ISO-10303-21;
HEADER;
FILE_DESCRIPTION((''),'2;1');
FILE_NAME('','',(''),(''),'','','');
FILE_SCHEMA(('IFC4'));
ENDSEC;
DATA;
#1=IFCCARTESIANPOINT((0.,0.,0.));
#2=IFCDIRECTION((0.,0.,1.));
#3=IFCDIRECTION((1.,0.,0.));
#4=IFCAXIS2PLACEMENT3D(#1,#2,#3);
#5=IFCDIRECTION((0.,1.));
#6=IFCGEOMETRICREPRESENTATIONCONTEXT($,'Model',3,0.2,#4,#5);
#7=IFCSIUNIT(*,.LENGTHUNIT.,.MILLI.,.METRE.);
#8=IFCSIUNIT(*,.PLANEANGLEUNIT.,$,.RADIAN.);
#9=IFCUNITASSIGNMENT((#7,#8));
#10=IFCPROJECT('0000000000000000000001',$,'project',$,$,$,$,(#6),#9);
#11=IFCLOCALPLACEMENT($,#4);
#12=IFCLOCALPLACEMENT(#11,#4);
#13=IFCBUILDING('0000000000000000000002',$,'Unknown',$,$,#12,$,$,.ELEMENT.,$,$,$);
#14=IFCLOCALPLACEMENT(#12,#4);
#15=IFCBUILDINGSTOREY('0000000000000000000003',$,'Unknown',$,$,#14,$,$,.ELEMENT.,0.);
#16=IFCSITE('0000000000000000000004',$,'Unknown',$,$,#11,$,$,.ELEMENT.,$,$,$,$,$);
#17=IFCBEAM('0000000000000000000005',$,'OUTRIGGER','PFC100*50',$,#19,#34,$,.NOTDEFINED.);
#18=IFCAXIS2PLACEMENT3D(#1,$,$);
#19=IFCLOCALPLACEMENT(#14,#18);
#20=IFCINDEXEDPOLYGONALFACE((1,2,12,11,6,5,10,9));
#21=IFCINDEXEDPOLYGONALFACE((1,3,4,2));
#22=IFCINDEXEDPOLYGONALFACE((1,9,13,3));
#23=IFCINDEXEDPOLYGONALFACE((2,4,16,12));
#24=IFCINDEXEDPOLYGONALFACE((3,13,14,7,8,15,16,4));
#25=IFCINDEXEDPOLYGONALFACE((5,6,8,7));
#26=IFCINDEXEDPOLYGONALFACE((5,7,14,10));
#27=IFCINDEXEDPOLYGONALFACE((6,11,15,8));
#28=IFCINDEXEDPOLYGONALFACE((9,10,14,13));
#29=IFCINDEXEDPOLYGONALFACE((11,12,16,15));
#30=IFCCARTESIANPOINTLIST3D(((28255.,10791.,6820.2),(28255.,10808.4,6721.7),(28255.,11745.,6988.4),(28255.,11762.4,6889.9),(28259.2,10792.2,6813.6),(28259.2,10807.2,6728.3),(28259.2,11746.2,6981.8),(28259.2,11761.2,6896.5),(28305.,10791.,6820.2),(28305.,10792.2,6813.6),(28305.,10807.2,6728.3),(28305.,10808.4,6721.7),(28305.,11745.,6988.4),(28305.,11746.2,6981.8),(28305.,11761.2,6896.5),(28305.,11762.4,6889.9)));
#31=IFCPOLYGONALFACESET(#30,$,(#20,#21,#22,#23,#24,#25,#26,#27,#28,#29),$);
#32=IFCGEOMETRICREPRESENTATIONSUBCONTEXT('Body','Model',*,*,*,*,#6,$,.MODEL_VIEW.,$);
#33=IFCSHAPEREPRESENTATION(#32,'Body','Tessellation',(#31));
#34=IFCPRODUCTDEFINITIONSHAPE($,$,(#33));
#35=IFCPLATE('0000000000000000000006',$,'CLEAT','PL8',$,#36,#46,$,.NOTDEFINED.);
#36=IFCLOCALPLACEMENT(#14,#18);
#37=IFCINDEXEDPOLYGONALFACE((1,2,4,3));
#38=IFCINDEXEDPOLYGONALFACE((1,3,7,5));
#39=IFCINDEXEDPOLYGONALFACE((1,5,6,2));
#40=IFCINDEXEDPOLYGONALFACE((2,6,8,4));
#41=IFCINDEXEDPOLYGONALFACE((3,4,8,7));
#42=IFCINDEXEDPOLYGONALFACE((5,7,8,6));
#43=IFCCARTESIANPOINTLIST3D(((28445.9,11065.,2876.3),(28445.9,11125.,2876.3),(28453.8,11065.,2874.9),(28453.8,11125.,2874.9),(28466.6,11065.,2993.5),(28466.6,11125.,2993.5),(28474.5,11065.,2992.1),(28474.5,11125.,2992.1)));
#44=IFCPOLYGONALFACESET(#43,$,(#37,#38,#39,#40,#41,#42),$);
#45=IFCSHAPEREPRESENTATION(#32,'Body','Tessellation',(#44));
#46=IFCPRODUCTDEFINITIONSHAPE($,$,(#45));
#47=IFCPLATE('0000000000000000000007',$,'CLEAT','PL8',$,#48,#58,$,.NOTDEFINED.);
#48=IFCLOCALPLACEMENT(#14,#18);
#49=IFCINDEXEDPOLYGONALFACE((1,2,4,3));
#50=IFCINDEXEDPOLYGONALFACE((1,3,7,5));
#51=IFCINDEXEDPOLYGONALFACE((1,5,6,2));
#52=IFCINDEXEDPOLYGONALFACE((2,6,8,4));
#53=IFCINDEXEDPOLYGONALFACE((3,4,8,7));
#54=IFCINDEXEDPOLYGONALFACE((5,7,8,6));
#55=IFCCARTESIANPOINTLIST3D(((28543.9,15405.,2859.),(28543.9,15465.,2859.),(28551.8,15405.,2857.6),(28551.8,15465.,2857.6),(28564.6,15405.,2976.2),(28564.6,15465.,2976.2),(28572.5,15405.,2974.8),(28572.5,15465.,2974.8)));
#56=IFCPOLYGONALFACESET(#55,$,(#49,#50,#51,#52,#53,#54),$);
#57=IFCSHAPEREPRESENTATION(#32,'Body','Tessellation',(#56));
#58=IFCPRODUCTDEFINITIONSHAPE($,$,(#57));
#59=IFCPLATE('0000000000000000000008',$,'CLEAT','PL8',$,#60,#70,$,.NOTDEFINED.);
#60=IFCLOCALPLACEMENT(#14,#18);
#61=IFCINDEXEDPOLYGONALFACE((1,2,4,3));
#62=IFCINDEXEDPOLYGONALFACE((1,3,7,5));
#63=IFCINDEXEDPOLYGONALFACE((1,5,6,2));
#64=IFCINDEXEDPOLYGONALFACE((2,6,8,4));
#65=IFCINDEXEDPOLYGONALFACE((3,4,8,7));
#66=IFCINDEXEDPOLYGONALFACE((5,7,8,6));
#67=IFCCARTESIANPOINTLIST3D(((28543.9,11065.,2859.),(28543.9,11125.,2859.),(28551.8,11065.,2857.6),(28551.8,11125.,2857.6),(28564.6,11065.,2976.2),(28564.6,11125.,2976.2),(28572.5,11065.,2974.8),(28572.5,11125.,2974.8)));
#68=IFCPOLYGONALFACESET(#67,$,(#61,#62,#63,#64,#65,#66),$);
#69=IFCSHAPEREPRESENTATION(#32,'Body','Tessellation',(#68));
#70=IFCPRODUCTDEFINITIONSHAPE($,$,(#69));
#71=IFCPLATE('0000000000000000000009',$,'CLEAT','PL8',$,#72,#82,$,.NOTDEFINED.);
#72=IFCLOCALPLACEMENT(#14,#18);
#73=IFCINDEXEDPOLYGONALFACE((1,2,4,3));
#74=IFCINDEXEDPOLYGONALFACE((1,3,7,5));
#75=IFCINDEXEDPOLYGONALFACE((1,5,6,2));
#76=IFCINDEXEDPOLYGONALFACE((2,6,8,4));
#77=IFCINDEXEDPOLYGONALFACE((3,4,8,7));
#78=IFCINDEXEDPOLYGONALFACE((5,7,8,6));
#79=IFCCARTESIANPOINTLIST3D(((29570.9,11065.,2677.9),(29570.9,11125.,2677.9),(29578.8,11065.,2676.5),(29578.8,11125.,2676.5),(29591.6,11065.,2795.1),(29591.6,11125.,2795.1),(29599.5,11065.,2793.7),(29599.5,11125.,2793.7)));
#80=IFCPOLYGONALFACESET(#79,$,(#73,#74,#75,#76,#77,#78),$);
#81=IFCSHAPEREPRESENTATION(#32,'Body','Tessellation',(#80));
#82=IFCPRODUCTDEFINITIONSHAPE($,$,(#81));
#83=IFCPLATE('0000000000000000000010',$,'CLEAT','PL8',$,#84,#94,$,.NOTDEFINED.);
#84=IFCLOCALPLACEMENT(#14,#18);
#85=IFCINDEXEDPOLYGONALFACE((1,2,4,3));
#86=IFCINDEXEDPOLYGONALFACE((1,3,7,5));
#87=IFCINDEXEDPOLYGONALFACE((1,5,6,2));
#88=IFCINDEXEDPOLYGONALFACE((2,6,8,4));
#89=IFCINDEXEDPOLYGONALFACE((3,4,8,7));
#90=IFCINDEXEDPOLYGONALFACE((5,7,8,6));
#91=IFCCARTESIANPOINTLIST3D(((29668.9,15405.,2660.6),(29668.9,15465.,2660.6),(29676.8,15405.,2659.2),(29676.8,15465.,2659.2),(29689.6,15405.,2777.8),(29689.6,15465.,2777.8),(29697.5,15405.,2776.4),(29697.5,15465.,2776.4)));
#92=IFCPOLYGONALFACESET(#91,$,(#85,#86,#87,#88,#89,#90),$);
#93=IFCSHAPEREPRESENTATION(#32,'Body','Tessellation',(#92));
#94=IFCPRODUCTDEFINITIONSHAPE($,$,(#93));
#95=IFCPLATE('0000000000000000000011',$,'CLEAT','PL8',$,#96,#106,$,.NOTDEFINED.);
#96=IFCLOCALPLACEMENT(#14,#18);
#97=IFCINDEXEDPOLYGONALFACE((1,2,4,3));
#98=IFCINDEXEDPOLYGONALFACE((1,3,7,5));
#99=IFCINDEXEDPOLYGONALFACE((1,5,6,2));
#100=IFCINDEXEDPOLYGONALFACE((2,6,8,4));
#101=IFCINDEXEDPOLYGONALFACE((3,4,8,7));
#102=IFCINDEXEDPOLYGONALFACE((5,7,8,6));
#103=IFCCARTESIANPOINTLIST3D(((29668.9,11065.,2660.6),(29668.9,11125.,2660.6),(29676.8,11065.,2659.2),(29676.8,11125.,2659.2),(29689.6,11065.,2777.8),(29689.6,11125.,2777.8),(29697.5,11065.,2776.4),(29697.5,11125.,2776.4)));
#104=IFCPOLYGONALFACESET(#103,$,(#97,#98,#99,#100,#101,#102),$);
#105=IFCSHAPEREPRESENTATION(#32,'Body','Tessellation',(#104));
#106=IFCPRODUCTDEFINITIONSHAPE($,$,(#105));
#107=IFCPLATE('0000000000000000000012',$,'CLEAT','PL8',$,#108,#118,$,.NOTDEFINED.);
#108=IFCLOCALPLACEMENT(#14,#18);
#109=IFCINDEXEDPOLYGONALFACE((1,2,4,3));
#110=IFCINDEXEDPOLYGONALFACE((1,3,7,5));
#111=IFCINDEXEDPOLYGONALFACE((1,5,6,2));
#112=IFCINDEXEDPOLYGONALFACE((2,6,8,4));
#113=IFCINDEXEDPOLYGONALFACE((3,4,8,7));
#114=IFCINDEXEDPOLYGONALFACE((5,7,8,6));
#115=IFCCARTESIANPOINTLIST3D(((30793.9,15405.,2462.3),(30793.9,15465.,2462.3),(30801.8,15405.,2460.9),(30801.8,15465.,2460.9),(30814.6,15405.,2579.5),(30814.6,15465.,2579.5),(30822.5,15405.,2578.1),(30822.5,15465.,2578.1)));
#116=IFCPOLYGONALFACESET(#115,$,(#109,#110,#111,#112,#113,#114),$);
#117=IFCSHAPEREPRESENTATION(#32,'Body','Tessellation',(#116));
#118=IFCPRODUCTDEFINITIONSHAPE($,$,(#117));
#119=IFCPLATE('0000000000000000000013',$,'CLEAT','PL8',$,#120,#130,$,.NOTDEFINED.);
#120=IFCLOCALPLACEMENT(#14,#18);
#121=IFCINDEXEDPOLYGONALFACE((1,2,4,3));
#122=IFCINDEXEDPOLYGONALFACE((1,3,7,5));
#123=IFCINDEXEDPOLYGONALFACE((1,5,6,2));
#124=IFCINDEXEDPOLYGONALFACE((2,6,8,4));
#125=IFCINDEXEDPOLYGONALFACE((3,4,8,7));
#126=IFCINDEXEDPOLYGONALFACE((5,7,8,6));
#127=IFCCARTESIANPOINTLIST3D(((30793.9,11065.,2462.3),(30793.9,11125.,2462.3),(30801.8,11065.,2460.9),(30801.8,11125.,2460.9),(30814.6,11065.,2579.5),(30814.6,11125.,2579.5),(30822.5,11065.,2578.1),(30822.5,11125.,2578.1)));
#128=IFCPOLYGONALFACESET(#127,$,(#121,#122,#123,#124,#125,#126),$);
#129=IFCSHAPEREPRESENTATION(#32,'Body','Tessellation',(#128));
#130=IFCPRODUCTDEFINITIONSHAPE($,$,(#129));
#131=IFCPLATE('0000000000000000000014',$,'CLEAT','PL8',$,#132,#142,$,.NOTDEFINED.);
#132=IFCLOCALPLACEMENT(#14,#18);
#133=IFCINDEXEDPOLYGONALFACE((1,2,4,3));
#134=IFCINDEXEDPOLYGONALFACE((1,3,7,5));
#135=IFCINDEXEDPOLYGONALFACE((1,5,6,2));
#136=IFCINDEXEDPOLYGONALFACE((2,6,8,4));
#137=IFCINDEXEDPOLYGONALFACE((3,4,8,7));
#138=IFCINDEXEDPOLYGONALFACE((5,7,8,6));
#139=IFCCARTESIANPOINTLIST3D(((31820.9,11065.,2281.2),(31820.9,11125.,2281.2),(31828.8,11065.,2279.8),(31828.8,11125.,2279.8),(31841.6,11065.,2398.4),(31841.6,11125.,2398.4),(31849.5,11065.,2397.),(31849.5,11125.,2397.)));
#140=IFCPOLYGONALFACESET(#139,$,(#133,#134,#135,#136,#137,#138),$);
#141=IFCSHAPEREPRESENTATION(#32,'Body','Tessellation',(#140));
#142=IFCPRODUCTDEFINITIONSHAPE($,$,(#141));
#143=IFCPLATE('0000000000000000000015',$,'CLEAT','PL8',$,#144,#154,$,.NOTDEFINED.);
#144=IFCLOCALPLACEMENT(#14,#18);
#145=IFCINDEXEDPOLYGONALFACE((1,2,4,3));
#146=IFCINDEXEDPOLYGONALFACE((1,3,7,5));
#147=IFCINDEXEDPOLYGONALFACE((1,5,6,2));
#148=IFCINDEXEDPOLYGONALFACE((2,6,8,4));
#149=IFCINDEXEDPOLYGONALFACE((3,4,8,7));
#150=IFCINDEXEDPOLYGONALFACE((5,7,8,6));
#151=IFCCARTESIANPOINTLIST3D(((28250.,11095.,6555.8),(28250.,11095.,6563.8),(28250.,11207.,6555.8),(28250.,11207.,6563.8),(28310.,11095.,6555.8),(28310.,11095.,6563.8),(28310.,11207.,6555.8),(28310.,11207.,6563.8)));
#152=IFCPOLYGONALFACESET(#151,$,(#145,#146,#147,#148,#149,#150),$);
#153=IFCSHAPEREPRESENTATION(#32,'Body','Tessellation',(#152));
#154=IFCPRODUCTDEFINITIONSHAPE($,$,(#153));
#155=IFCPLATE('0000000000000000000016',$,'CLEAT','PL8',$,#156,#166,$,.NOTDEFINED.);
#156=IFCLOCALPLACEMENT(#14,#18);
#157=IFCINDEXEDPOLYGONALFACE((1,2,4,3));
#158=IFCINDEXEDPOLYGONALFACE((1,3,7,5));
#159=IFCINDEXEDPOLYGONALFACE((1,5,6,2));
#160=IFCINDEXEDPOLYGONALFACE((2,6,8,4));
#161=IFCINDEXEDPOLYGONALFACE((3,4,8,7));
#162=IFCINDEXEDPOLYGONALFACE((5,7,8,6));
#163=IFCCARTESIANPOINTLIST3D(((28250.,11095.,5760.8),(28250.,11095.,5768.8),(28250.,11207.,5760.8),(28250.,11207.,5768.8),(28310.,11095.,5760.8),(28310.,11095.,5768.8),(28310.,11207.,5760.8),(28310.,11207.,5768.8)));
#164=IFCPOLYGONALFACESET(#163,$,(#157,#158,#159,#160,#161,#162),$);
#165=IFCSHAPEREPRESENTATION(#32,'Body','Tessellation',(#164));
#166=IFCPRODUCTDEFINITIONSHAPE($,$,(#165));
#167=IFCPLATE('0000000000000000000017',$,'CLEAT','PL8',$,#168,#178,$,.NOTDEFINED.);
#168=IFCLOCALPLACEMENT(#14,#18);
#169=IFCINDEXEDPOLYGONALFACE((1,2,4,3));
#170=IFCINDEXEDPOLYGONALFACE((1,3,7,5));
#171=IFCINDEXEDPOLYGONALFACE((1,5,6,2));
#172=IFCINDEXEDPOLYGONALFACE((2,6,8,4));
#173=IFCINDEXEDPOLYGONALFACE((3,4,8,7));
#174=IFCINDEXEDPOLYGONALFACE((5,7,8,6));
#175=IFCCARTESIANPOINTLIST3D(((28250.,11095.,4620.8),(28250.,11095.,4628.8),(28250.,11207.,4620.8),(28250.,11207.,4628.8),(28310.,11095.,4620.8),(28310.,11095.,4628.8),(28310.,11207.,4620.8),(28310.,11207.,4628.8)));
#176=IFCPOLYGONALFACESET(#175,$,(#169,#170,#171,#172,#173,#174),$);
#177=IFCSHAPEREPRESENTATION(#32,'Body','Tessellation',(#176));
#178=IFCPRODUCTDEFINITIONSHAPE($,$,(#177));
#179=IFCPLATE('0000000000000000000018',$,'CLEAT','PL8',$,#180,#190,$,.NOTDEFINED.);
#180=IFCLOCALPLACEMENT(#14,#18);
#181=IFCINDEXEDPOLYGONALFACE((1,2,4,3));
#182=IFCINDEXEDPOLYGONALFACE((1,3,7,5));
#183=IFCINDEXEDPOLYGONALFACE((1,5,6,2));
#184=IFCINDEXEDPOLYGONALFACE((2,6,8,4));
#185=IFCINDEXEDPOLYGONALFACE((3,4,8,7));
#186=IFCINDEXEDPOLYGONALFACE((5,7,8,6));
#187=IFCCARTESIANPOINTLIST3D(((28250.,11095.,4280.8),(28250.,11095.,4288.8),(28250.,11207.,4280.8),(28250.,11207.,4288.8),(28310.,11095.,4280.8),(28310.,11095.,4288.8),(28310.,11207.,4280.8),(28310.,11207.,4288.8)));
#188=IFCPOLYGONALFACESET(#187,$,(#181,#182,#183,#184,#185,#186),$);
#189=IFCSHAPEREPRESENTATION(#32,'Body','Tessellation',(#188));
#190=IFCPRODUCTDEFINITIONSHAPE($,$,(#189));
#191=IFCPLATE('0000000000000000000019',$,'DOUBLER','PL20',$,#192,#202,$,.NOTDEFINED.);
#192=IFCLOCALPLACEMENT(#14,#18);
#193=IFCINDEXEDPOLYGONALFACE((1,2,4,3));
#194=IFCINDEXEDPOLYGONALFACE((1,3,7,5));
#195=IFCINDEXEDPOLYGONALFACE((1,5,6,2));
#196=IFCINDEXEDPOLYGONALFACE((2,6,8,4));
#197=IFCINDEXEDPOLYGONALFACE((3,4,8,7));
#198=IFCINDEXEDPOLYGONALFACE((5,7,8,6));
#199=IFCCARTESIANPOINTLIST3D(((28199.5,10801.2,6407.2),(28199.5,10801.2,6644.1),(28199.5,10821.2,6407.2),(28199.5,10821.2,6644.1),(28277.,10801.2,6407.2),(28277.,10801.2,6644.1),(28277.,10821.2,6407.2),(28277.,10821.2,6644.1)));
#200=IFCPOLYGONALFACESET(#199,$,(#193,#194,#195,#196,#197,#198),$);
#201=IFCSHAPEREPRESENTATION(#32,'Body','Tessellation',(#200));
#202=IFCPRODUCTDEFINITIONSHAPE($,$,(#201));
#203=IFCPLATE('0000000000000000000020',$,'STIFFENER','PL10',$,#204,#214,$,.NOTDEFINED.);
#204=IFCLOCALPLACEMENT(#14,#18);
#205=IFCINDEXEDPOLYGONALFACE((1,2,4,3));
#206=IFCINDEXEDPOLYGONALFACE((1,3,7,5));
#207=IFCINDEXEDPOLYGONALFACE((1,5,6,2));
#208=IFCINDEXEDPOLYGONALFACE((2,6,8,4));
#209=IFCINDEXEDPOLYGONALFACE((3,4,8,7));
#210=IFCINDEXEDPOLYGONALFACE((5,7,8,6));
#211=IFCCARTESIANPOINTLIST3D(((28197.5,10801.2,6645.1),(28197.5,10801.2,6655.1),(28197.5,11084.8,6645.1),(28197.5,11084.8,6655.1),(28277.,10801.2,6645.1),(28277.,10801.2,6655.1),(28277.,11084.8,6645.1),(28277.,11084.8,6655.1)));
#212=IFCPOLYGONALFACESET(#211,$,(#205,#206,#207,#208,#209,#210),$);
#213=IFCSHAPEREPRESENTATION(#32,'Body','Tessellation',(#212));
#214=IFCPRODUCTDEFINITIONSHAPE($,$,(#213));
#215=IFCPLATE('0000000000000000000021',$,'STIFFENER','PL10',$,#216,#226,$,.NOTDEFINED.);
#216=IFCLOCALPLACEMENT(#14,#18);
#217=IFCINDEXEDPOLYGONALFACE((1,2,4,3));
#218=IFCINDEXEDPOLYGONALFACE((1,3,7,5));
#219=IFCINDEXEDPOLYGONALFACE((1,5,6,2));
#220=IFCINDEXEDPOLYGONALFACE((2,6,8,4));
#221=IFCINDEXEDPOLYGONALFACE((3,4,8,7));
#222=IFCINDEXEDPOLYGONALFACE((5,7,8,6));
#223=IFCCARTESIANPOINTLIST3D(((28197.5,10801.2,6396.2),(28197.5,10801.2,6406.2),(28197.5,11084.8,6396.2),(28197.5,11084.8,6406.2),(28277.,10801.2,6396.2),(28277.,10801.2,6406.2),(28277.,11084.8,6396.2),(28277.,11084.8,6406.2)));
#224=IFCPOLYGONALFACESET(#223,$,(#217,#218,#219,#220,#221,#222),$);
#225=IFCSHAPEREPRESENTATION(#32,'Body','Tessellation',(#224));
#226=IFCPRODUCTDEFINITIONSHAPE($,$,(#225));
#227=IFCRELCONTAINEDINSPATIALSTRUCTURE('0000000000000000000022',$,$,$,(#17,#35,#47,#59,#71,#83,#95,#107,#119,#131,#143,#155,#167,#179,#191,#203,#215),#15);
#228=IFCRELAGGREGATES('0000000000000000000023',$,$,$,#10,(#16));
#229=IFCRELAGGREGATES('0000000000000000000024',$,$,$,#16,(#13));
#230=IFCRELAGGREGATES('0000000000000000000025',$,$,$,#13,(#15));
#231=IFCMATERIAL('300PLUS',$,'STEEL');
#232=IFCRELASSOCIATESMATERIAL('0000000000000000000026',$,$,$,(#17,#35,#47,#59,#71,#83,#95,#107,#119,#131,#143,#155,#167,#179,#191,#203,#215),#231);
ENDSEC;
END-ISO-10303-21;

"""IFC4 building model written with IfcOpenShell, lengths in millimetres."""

from ifc_helpers import new_model, si_unit, direction, frame, origin_with_axes, place, context, subcontext, project, spatial, line, indexed_curve, outline, extrude, material, element, save


model = new_model("IFC4")

# Units and contexts
model_context = context("Model", 3, precision=0.2, world=origin_with_axes(), true_north=direction((0.0, 1.0)))
body_context = subcontext(model_context, "Body", "Model", "MODEL_VIEW")
ifc_project = project(units=[si_unit("LENGTHUNIT", "METRE", prefix="MILLI"), si_unit("PLANEANGLEUNIT", "RADIAN")], contexts=[model_context])

# Site, building, storey
site_placement = place(None, origin_with_axes())
site = spatial("IfcSite", under=ifc_project, at=site_placement, Name="Unknown", CompositionType="ELEMENT")
building_placement = place(site_placement, origin_with_axes())
building = spatial("IfcBuilding", under=site, at=building_placement, Name="Unknown", CompositionType="ELEMENT")
storey_placement = place(building_placement, origin_with_axes())
storey = spatial("IfcBuildingStorey", under=building, at=storey_placement, Name="Unknown", CompositionType="ELEMENT", Elevation=0.0)

# Beam
ifc_material_1 = material(Name="300PLUS", Category="STEEL")
beam_1_placement = place(storey_placement, frame((28280.0, 10799.7, 6771.0), z_axis=(1.0, 0.0, 0.0), x_axis=(0.0, 0.984811, 0.173632)))
element("IfcBeam", 1, at=beam_1_placement, inside=storey, material=ifc_material_1, Name="OUTRIGGER", Description="PFC100*50", PredefinedType="NOTDEFINED", context=body_context, shape_type="SolidModel", body=[
    extrude(outline(indexed_curve([(-25.0, -50.0), (25.0, -50.0), (25.0, -43.3), (-20.8, -43.3), (-20.8, 43.3), (25.0, 43.3), (25.0, 50.0), (-25.0, 50.0)], segments=[line(1, 2, 3, 4, 5, 6, 7, 8, 1)])), frame((0.0, 0.0, 0.0), z_axis=(-1.0, 0.0, 0.0), x_axis=(0.0, 0.0, 1.0)), (0.0, 0.0, -1.0), 968.7),
])

# Plates
for number, where, z_axis, x_axis, name in (
    (2, (28449.9, 11125.0, 2875.6), (-0.984758, 0.0, 0.173929), (0.0, -1.0, 0.0), "CLEAT"),
    (3, (28547.9, 15465.0, 2858.3), (-0.984758, 0.0, 0.173929), (0.0, -1.0, 0.0), "CLEAT"),
    (4, (28547.9, 11125.0, 2858.3), (-0.984758, 0.0, 0.173929), (0.0, -1.0, 0.0), "CLEAT"),
    (5, (29574.9, 11125.0, 2677.2), (-0.984758, 0.0, 0.173929), (0.0, -1.0, 0.0), "CLEAT"),
    (6, (29672.9, 15465.0, 2659.9), (-0.984758, 0.0, 0.173929), (0.0, -1.0, 0.0), "CLEAT"),
    (7, (29672.9, 11125.0, 2659.9), (-0.984758, 0.0, 0.173929), (0.0, -1.0, 0.0), "CLEAT"),
    (8, (30797.9, 15465.0, 2461.6), (-0.984758, 0.0, 0.173929), (0.0, -1.0, 0.0), "CLEAT"),
    (9, (30797.9, 11125.0, 2461.6), (-0.984758, 0.0, 0.173929), (0.0, -1.0, 0.0), "CLEAT"),
    (10, (31824.9, 11125.0, 2280.5), (-0.984758, 0.0, 0.173929), (0.0, -1.0, 0.0), "CLEAT"),
):
    element("IfcPlate", number, at=place(storey_placement, frame(where, z_axis=z_axis, x_axis=x_axis)), inside=storey, material=ifc_material_1, Name=name, Description="PL8", PredefinedType="NOTDEFINED", context=body_context, shape_type="SolidModel", body=[
        extrude(outline(indexed_curve([(0.0, 0.0), (60.0, 0.0), (60.0, 119.0), (0.0, 119.0)], segments=[line(1, 2, 3, 4, 1)])), frame((0.0, 0.0, 4.0), z_axis=(0.0, 0.0, 1.0), x_axis=(1.0, 0.0, 0.0)), (0.0, 0.0, -1.0), 8.0),
    ])
for number, where, z_axis, x_axis, name in (
    (11, (28250.0, 11095.0, 6559.8), (0.0, 0.0, 1.0), (1.0, 0.0, 0.0), "CLEAT"),
    (12, (28250.0, 11095.0, 5764.8), (0.0, 0.0, 1.0), (1.0, 0.0, 0.0), "CLEAT"),
    (13, (28250.0, 11095.0, 4624.8), (0.0, 0.0, 1.0), (1.0, 0.0, 0.0), "CLEAT"),
    (14, (28250.0, 11095.0, 4284.8), (0.0, 0.0, 1.0), (1.0, 0.0, 0.0), "CLEAT"),
):
    element("IfcPlate", number, at=place(storey_placement, frame(where, z_axis=z_axis, x_axis=x_axis)), inside=storey, material=ifc_material_1, Name=name, Description="PL8", PredefinedType="NOTDEFINED", context=body_context, shape_type="SolidModel", body=[
        extrude(outline(indexed_curve([(0.0, 0.0), (60.0, 0.0), (60.0, 112.0), (0.0, 112.0)], segments=[line(1, 2, 3, 4, 1)])), frame((0.0, 0.0, 4.0), z_axis=(0.0, 0.0, 1.0), x_axis=(1.0, 0.0, 0.0)), (0.0, 0.0, -1.0), 8.0),
    ])
plate_1_placement = place(storey_placement, frame((28199.5, 10811.2, 6407.2), z_axis=(0.0, -1.0, 0.0), x_axis=(1.0, 0.0, 0.0)))
element("IfcPlate", 15, at=plate_1_placement, inside=storey, material=ifc_material_1, Name="DOUBLER", Description="PL20", PredefinedType="NOTDEFINED", context=body_context, shape_type="SolidModel", body=[
    extrude(outline(indexed_curve([(0.0, 0.0), (77.5, 0.0), (77.5, 236.9), (0.0, 236.9)], segments=[line(1, 2, 3, 4, 1)])), frame((0.0, 0.0, 10.0), z_axis=(0.0, 0.0, 1.0), x_axis=(1.0, 0.0, 0.0)), (0.0, 0.0, -1.0), 20.0),
])
for number, where, z_axis, x_axis, name in (
    (16, (28197.5, 10801.2, 6650.1), (0.0, 0.0, 1.0), (1.0, 0.0, 0.0), "STIFFENER"),
    (17, (28197.5, 10801.2, 6401.2), (0.0, 0.0, 1.0), (1.0, 0.0, 0.0), "STIFFENER"),
):
    element("IfcPlate", number, at=place(storey_placement, frame(where, z_axis=z_axis, x_axis=x_axis)), inside=storey, material=ifc_material_1, Name=name, Description="PL10", PredefinedType="NOTDEFINED", context=body_context, shape_type="SolidModel", body=[
        extrude(outline(indexed_curve([(0.0, 0.0), (79.5, 0.0), (79.5, 283.6), (0.0, 283.6)], segments=[line(1, 2, 3, 4, 1)])), frame((0.0, 0.0, 5.0), z_axis=(0.0, 0.0, 1.0), x_axis=(1.0, 0.0, 0.0)), (0.0, 0.0, -1.0), 10.0),
    ])

save(model, "model.ifc")
